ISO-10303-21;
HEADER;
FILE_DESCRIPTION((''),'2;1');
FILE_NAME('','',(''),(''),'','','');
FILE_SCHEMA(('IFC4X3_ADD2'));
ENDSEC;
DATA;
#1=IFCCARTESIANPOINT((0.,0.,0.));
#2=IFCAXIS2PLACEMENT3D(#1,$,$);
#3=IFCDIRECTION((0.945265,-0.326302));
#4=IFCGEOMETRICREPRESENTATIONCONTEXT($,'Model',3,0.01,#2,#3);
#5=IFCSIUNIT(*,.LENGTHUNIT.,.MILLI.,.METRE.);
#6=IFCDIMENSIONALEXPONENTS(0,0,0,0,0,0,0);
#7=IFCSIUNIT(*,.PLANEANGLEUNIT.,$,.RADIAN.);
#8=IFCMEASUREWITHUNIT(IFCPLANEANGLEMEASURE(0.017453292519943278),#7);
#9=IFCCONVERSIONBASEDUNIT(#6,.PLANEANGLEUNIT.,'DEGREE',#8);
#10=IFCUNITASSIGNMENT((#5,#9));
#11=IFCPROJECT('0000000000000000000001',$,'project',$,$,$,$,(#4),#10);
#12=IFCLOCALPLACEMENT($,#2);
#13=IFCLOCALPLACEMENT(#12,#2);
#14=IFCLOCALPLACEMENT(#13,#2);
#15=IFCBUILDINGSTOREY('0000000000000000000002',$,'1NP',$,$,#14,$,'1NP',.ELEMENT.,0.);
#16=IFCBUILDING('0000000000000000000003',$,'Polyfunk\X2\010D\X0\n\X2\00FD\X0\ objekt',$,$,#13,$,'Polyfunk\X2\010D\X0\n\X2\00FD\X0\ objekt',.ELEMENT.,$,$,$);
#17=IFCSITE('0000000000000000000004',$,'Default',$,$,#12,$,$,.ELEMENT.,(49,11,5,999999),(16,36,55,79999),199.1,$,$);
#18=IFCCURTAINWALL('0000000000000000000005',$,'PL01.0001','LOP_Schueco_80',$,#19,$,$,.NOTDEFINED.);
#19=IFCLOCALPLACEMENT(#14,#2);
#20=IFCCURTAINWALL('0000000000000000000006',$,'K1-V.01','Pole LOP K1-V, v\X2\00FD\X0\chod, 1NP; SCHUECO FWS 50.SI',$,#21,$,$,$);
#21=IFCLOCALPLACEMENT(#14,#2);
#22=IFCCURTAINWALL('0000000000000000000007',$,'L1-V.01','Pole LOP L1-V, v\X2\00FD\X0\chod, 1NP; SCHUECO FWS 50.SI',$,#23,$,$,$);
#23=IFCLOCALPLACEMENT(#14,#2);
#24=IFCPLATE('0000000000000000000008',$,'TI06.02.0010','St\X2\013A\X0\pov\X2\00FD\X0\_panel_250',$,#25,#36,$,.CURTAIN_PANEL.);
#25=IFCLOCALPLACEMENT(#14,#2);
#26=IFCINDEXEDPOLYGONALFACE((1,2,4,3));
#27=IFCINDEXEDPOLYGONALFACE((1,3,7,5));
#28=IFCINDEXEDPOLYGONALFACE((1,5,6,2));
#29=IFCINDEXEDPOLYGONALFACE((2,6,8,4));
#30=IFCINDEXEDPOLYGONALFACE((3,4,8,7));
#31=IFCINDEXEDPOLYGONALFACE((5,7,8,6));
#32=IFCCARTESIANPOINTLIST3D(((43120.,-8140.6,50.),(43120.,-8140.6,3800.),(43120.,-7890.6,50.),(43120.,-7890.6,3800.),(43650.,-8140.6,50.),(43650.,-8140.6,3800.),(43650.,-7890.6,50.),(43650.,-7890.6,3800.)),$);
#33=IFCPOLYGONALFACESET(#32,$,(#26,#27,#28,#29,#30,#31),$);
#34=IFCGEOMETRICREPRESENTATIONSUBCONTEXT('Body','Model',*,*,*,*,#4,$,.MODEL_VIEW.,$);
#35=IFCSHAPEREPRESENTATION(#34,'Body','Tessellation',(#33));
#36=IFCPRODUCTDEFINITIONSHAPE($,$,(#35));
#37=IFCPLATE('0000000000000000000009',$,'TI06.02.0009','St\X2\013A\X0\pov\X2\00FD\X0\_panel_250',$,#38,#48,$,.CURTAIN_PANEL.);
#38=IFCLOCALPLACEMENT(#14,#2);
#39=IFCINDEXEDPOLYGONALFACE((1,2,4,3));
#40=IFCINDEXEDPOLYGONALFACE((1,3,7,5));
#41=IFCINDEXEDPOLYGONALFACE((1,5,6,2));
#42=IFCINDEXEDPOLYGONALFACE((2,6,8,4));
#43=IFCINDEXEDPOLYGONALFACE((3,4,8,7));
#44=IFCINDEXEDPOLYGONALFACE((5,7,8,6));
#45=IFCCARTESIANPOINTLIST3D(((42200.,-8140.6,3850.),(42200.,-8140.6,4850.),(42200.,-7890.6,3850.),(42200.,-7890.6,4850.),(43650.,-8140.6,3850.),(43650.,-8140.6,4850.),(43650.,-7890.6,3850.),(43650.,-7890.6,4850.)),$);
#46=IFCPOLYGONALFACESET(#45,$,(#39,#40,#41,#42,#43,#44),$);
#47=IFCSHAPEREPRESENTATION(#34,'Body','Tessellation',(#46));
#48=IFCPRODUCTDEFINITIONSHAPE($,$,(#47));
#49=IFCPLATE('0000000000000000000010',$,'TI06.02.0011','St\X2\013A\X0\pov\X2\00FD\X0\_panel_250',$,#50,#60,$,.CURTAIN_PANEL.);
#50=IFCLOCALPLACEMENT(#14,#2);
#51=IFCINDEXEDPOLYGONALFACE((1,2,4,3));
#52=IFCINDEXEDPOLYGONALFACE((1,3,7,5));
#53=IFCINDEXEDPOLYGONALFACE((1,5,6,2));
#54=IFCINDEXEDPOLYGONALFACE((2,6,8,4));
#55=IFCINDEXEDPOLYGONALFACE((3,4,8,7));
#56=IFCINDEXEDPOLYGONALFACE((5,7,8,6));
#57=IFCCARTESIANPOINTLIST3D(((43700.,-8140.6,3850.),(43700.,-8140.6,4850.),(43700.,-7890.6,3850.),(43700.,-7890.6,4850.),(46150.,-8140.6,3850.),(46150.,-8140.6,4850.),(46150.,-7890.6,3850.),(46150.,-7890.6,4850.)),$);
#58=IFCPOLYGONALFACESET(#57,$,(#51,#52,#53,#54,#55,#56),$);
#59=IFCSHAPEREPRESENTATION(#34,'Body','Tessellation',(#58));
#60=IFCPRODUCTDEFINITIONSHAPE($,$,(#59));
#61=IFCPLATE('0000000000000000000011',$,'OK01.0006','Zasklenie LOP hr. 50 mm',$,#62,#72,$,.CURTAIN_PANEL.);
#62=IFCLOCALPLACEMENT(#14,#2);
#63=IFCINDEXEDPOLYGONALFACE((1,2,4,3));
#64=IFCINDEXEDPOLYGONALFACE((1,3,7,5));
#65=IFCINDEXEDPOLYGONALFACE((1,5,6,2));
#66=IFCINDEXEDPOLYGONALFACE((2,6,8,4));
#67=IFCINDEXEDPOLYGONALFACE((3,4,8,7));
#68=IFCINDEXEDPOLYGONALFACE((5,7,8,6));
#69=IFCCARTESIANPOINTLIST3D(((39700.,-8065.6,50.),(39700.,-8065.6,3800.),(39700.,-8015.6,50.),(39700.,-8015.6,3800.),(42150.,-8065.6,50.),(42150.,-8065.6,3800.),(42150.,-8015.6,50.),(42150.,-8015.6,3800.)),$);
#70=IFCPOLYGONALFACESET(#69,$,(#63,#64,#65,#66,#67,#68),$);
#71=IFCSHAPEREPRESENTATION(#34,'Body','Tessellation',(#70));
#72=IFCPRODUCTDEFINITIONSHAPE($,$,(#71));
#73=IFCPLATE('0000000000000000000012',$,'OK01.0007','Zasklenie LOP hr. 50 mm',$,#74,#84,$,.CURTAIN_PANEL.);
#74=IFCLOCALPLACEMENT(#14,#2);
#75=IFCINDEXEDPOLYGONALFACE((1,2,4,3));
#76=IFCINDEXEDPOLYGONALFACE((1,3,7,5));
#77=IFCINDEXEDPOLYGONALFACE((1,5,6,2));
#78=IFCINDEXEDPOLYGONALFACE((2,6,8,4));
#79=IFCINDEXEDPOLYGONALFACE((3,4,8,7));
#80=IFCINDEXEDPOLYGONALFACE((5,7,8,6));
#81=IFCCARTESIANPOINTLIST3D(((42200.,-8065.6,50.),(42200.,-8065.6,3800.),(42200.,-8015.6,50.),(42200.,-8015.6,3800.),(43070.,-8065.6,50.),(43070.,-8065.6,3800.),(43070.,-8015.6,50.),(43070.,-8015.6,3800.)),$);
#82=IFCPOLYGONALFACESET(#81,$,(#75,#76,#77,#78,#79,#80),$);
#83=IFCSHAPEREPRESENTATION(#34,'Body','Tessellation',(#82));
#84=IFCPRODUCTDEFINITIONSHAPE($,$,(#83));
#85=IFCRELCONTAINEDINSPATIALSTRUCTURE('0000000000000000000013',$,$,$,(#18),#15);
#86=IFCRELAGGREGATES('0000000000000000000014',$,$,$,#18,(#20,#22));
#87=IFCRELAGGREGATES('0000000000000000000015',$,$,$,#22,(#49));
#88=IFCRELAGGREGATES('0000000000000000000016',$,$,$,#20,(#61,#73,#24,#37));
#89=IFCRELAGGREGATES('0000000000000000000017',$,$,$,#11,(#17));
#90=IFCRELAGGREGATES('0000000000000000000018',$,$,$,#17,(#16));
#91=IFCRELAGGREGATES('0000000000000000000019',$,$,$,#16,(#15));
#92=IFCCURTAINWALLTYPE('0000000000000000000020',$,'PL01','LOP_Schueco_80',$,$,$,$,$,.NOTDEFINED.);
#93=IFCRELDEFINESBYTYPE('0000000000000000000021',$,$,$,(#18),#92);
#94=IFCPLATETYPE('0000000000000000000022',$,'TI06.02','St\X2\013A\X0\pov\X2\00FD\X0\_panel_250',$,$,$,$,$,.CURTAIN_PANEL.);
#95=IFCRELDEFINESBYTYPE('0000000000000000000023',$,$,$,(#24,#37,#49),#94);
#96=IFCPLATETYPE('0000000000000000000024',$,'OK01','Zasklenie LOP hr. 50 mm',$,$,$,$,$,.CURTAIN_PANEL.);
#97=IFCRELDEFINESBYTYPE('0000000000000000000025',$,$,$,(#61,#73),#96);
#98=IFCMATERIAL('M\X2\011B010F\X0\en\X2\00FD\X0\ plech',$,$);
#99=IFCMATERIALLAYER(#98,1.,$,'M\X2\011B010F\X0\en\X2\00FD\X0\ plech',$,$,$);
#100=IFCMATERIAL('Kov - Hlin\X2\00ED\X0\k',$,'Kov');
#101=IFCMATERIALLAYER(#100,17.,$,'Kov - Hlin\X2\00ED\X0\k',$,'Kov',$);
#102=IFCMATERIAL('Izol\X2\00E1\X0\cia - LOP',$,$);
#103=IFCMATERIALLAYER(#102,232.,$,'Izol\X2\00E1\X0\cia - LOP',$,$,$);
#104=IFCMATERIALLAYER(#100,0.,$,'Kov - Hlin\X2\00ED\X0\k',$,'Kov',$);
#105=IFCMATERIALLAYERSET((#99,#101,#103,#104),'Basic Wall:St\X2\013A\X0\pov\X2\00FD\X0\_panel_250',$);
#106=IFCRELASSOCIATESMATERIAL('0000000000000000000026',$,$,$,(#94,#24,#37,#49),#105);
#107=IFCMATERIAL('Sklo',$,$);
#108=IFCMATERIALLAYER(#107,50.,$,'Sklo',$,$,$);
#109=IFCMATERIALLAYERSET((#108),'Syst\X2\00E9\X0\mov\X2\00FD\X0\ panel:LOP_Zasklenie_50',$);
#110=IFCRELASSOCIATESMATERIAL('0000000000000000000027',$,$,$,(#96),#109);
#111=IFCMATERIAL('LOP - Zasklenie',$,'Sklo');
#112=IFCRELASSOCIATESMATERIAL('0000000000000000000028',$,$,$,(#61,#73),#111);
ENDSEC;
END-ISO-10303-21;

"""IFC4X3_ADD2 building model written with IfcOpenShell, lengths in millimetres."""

from ifc_helpers import new_model, entity, si_unit, converted_unit, direction, frame, frame_2d, origin, place, context, subcontext, project, spatial, rectangle, extrude, source, transform, mapped, material, layer, layer_set, layer_usage, type_object, type_shapes, element, aggregate, save


model = new_model("IFC4X3_ADD2")

# Units and contexts
model_context = context("Model", 3, precision=0.01, world=origin(), true_north=direction((0.945265, -0.326302)))
body_context = subcontext(model_context, "Body", "Model", "MODEL_VIEW")
ifc_project = project(units=[si_unit("LENGTHUNIT", "METRE", prefix="MILLI"), converted_unit("PLANEANGLEUNIT", "DEGREE", entity("IfcPlaneAngleMeasure", 0.017453292519943278), si_unit("PLANEANGLEUNIT", "RADIAN"), dimensions=[0, 0, 0, 0, 0, 0, 0])], contexts=[model_context])

# Site, building, storey
site_placement = place(None, origin())
site = spatial("IfcSite", under=ifc_project, at=site_placement, Name="Default", CompositionType="ELEMENT", RefLatitude=(49, 11, 5, 999999), RefLongitude=(16, 36, 55, 79999), RefElevation=199.1)
building_placement = place(site_placement, origin())
building = spatial("IfcBuilding", under=site, at=building_placement, Name="Polyfunkčný objekt", LongName="Polyfunkčný objekt", CompositionType="ELEMENT")
storey_placement = place(building_placement, origin())
storey = spatial("IfcBuildingStorey", under=building, at=storey_placement, Name="1NP", LongName="1NP", CompositionType="ELEMENT", Elevation=0.0)

# Curtain walls, plates
curtain_wall_type = type_object("IfcCurtainWallType", Name="PL01", Description="LOP_Schueco_80", PredefinedType="NOTDEFINED")
curtain_wall_1_placement = place(storey_placement, origin())
curtain_wall_1 = element("IfcCurtainWall", 1, at=curtain_wall_1_placement, inside=storey, type_object=curtain_wall_type, Name="PL01.0001", Description="LOP_Schueco_80", PredefinedType="NOTDEFINED")
curtain_wall_2 = element("IfcCurtainWall", 2, Name="K1-V.01", Description="Pole LOP K1-V, východ, 1NP; SCHUECO FWS 50.SI")
curtain_wall_3 = element("IfcCurtainWall", 3, Name="L1-V.01", Description="Pole LOP L1-V, východ, 1NP; SCHUECO FWS 50.SI")
aggregate(curtain_wall_1, [curtain_wall_2, curtain_wall_3])
ifc_material_1 = material(Name="Měďený plech")
ifc_layer_1 = layer(ifc_material_1, 1.0, Name="Měďený plech")
ifc_material_2 = material(Name="Kov - Hliník", Category="Kov")
ifc_layer_2 = layer(ifc_material_2, 17.0, Name="Kov - Hliník", Category="Kov")
ifc_material_3 = material(Name="Izolácia - LOP")
ifc_layer_3 = layer(ifc_material_3, 232.0, Name="Izolácia - LOP")
ifc_layer_4 = layer(ifc_material_2, 0.0, Name="Kov - Hliník", Category="Kov")
ifc_layer_set_1 = layer_set([ifc_layer_1, ifc_layer_2, ifc_layer_3, ifc_layer_4], Name="Basic Wall:Stĺpový_panel_250")
ifc_layer_usage_1 = layer_usage(ifc_layer_set_1, "AXIS2", "POSITIVE", -125.0)
plate_type_1 = type_object("IfcPlateType", Name="TI06.02", Description="Stĺpový_panel_250", PredefinedType="CURTAIN_PANEL", material=ifc_layer_set_1)
plate_1_placement = place(storey_placement, frame((43120.0, -8015.6, 50.0)))
plate_1 = element("IfcPlate", 4, at=plate_1_placement, type_object=plate_type_1, material=ifc_layer_usage_1, Name="TI06.02.0010", Description="Stĺpový_panel_250", PredefinedType="CURTAIN_PANEL", context=body_context, shape_type="SweptSolid", body=[
    extrude(rectangle(XDim=250.0, YDim=530.0, at=frame_2d((0.0, 0.0), x_axis=(1.0, 0.0))), frame((265.0, 0.0, 0.0), z_axis=(0.0, 0.0, 1.0), x_axis=(0.0, 1.0, 0.0)), (0.0, 0.0, 1.0), 3750.0),
])
ifc_layer_usage_2 = layer_usage(ifc_layer_set_1, "AXIS2", "POSITIVE", -125.0)
plate_2_placement = place(storey_placement, frame((42200.0, -8015.6, 3850.0)))
plate_2 = element("IfcPlate", 5, at=plate_2_placement, type_object=plate_type_1, material=ifc_layer_usage_2, Name="TI06.02.0009", Description="Stĺpový_panel_250", PredefinedType="CURTAIN_PANEL", context=body_context, shape_type="SweptSolid", body=[
    extrude(rectangle(XDim=250.0, YDim=1450.0, at=frame_2d((0.0, 0.0), x_axis=(1.0, 0.0))), frame((725.0, 0.0, 0.0), z_axis=(0.0, 0.0, 1.0), x_axis=(0.0, 1.0, 0.0)), (0.0, 0.0, 1.0), 1000.0),
])
ifc_layer_usage_3 = layer_usage(ifc_layer_set_1, "AXIS2", "POSITIVE", -125.0)
plate_3_placement = place(storey_placement, frame((43700.0, -8015.6, 3850.0)))
plate_3 = element("IfcPlate", 6, at=plate_3_placement, type_object=plate_type_1, material=ifc_layer_usage_3, Name="TI06.02.0011", Description="Stĺpový_panel_250", PredefinedType="CURTAIN_PANEL", context=body_context, shape_type="SweptSolid", body=[
    extrude(rectangle(XDim=250.0, YDim=2450.0, at=frame_2d((0.0, 0.0), x_axis=(1.0, 0.0))), frame((1225.0, 0.0, 0.0), z_axis=(0.0, 0.0, 1.0), x_axis=(0.0, 1.0, 0.0)), (0.0, 0.0, 1.0), 1000.0),
])
aggregate(curtain_wall_3, [plate_3])
ifc_material_4 = material(Name="LOP - Zasklenie", Category="Sklo")
ifc_material_5 = material(Name="Sklo")
ifc_layer_5 = layer(ifc_material_5, 50.0, Name="Sklo")
ifc_layer_set_2 = layer_set([ifc_layer_5], Name="Systémový panel:LOP_Zasklenie_50")
plate_type_2 = type_object("IfcPlateType", Name="OK01", Description="Zasklenie LOP hr. 50 mm", PredefinedType="CURTAIN_PANEL", material=ifc_layer_set_2)
shared_shape_1 = source(origin(), body_context, "Body", "SweptSolid", [
    extrude(rectangle(XDim=3750.0, YDim=2450.0, at=frame_2d((-331.2, 0.0), x_axis=(1.0, 0.0))), frame((0.0, -50.0, 2206.2), z_axis=(0.0, 1.0, 0.0), x_axis=(0.0, 0.0, 1.0)), (0.0, 0.0, 1.0), 50.0),
])
plate_4_placement = place(curtain_wall_1_placement, frame((40925.0, -8015.6, 50.0)))
plate_4 = element("IfcPlate", 7, at=plate_4_placement, type_object=plate_type_2, material=ifc_material_4, Name="OK01.0006", Description="Zasklenie LOP hr. 50 mm", PredefinedType="CURTAIN_PANEL", context=body_context, shape_type="MappedRepresentation", body=[
    mapped(shared_shape_1, transform((0.0, 0.0, 0.0), scale=1.0)),
])
shared_shape_2 = source(origin(), body_context, "Body", "SweptSolid", [
    extrude(rectangle(XDim=3750.0, YDim=870.0, at=frame_2d((-331.2, 0.0), x_axis=(1.0, 0.0))), frame((0.0, -50.0, 2206.2), z_axis=(0.0, 1.0, 0.0), x_axis=(0.0, 0.0, 1.0)), (0.0, 0.0, 1.0), 50.0),
])
type_shapes(plate_type_2, [shared_shape_1, shared_shape_2])
plate_5_placement = place(curtain_wall_1_placement, frame((42635.0, -8015.6, 50.0)))
plate_5 = element("IfcPlate", 8, at=plate_5_placement, type_object=plate_type_2, material=ifc_material_4, Name="OK01.0007", Description="Zasklenie LOP hr. 50 mm", PredefinedType="CURTAIN_PANEL", context=body_context, shape_type="MappedRepresentation", body=[
    mapped(shared_shape_2, transform((0.0, 0.0, 0.0), scale=1.0)),
])
aggregate(curtain_wall_2, [plate_4, plate_5, plate_1, plate_2])

save(model, "model.ifc")
